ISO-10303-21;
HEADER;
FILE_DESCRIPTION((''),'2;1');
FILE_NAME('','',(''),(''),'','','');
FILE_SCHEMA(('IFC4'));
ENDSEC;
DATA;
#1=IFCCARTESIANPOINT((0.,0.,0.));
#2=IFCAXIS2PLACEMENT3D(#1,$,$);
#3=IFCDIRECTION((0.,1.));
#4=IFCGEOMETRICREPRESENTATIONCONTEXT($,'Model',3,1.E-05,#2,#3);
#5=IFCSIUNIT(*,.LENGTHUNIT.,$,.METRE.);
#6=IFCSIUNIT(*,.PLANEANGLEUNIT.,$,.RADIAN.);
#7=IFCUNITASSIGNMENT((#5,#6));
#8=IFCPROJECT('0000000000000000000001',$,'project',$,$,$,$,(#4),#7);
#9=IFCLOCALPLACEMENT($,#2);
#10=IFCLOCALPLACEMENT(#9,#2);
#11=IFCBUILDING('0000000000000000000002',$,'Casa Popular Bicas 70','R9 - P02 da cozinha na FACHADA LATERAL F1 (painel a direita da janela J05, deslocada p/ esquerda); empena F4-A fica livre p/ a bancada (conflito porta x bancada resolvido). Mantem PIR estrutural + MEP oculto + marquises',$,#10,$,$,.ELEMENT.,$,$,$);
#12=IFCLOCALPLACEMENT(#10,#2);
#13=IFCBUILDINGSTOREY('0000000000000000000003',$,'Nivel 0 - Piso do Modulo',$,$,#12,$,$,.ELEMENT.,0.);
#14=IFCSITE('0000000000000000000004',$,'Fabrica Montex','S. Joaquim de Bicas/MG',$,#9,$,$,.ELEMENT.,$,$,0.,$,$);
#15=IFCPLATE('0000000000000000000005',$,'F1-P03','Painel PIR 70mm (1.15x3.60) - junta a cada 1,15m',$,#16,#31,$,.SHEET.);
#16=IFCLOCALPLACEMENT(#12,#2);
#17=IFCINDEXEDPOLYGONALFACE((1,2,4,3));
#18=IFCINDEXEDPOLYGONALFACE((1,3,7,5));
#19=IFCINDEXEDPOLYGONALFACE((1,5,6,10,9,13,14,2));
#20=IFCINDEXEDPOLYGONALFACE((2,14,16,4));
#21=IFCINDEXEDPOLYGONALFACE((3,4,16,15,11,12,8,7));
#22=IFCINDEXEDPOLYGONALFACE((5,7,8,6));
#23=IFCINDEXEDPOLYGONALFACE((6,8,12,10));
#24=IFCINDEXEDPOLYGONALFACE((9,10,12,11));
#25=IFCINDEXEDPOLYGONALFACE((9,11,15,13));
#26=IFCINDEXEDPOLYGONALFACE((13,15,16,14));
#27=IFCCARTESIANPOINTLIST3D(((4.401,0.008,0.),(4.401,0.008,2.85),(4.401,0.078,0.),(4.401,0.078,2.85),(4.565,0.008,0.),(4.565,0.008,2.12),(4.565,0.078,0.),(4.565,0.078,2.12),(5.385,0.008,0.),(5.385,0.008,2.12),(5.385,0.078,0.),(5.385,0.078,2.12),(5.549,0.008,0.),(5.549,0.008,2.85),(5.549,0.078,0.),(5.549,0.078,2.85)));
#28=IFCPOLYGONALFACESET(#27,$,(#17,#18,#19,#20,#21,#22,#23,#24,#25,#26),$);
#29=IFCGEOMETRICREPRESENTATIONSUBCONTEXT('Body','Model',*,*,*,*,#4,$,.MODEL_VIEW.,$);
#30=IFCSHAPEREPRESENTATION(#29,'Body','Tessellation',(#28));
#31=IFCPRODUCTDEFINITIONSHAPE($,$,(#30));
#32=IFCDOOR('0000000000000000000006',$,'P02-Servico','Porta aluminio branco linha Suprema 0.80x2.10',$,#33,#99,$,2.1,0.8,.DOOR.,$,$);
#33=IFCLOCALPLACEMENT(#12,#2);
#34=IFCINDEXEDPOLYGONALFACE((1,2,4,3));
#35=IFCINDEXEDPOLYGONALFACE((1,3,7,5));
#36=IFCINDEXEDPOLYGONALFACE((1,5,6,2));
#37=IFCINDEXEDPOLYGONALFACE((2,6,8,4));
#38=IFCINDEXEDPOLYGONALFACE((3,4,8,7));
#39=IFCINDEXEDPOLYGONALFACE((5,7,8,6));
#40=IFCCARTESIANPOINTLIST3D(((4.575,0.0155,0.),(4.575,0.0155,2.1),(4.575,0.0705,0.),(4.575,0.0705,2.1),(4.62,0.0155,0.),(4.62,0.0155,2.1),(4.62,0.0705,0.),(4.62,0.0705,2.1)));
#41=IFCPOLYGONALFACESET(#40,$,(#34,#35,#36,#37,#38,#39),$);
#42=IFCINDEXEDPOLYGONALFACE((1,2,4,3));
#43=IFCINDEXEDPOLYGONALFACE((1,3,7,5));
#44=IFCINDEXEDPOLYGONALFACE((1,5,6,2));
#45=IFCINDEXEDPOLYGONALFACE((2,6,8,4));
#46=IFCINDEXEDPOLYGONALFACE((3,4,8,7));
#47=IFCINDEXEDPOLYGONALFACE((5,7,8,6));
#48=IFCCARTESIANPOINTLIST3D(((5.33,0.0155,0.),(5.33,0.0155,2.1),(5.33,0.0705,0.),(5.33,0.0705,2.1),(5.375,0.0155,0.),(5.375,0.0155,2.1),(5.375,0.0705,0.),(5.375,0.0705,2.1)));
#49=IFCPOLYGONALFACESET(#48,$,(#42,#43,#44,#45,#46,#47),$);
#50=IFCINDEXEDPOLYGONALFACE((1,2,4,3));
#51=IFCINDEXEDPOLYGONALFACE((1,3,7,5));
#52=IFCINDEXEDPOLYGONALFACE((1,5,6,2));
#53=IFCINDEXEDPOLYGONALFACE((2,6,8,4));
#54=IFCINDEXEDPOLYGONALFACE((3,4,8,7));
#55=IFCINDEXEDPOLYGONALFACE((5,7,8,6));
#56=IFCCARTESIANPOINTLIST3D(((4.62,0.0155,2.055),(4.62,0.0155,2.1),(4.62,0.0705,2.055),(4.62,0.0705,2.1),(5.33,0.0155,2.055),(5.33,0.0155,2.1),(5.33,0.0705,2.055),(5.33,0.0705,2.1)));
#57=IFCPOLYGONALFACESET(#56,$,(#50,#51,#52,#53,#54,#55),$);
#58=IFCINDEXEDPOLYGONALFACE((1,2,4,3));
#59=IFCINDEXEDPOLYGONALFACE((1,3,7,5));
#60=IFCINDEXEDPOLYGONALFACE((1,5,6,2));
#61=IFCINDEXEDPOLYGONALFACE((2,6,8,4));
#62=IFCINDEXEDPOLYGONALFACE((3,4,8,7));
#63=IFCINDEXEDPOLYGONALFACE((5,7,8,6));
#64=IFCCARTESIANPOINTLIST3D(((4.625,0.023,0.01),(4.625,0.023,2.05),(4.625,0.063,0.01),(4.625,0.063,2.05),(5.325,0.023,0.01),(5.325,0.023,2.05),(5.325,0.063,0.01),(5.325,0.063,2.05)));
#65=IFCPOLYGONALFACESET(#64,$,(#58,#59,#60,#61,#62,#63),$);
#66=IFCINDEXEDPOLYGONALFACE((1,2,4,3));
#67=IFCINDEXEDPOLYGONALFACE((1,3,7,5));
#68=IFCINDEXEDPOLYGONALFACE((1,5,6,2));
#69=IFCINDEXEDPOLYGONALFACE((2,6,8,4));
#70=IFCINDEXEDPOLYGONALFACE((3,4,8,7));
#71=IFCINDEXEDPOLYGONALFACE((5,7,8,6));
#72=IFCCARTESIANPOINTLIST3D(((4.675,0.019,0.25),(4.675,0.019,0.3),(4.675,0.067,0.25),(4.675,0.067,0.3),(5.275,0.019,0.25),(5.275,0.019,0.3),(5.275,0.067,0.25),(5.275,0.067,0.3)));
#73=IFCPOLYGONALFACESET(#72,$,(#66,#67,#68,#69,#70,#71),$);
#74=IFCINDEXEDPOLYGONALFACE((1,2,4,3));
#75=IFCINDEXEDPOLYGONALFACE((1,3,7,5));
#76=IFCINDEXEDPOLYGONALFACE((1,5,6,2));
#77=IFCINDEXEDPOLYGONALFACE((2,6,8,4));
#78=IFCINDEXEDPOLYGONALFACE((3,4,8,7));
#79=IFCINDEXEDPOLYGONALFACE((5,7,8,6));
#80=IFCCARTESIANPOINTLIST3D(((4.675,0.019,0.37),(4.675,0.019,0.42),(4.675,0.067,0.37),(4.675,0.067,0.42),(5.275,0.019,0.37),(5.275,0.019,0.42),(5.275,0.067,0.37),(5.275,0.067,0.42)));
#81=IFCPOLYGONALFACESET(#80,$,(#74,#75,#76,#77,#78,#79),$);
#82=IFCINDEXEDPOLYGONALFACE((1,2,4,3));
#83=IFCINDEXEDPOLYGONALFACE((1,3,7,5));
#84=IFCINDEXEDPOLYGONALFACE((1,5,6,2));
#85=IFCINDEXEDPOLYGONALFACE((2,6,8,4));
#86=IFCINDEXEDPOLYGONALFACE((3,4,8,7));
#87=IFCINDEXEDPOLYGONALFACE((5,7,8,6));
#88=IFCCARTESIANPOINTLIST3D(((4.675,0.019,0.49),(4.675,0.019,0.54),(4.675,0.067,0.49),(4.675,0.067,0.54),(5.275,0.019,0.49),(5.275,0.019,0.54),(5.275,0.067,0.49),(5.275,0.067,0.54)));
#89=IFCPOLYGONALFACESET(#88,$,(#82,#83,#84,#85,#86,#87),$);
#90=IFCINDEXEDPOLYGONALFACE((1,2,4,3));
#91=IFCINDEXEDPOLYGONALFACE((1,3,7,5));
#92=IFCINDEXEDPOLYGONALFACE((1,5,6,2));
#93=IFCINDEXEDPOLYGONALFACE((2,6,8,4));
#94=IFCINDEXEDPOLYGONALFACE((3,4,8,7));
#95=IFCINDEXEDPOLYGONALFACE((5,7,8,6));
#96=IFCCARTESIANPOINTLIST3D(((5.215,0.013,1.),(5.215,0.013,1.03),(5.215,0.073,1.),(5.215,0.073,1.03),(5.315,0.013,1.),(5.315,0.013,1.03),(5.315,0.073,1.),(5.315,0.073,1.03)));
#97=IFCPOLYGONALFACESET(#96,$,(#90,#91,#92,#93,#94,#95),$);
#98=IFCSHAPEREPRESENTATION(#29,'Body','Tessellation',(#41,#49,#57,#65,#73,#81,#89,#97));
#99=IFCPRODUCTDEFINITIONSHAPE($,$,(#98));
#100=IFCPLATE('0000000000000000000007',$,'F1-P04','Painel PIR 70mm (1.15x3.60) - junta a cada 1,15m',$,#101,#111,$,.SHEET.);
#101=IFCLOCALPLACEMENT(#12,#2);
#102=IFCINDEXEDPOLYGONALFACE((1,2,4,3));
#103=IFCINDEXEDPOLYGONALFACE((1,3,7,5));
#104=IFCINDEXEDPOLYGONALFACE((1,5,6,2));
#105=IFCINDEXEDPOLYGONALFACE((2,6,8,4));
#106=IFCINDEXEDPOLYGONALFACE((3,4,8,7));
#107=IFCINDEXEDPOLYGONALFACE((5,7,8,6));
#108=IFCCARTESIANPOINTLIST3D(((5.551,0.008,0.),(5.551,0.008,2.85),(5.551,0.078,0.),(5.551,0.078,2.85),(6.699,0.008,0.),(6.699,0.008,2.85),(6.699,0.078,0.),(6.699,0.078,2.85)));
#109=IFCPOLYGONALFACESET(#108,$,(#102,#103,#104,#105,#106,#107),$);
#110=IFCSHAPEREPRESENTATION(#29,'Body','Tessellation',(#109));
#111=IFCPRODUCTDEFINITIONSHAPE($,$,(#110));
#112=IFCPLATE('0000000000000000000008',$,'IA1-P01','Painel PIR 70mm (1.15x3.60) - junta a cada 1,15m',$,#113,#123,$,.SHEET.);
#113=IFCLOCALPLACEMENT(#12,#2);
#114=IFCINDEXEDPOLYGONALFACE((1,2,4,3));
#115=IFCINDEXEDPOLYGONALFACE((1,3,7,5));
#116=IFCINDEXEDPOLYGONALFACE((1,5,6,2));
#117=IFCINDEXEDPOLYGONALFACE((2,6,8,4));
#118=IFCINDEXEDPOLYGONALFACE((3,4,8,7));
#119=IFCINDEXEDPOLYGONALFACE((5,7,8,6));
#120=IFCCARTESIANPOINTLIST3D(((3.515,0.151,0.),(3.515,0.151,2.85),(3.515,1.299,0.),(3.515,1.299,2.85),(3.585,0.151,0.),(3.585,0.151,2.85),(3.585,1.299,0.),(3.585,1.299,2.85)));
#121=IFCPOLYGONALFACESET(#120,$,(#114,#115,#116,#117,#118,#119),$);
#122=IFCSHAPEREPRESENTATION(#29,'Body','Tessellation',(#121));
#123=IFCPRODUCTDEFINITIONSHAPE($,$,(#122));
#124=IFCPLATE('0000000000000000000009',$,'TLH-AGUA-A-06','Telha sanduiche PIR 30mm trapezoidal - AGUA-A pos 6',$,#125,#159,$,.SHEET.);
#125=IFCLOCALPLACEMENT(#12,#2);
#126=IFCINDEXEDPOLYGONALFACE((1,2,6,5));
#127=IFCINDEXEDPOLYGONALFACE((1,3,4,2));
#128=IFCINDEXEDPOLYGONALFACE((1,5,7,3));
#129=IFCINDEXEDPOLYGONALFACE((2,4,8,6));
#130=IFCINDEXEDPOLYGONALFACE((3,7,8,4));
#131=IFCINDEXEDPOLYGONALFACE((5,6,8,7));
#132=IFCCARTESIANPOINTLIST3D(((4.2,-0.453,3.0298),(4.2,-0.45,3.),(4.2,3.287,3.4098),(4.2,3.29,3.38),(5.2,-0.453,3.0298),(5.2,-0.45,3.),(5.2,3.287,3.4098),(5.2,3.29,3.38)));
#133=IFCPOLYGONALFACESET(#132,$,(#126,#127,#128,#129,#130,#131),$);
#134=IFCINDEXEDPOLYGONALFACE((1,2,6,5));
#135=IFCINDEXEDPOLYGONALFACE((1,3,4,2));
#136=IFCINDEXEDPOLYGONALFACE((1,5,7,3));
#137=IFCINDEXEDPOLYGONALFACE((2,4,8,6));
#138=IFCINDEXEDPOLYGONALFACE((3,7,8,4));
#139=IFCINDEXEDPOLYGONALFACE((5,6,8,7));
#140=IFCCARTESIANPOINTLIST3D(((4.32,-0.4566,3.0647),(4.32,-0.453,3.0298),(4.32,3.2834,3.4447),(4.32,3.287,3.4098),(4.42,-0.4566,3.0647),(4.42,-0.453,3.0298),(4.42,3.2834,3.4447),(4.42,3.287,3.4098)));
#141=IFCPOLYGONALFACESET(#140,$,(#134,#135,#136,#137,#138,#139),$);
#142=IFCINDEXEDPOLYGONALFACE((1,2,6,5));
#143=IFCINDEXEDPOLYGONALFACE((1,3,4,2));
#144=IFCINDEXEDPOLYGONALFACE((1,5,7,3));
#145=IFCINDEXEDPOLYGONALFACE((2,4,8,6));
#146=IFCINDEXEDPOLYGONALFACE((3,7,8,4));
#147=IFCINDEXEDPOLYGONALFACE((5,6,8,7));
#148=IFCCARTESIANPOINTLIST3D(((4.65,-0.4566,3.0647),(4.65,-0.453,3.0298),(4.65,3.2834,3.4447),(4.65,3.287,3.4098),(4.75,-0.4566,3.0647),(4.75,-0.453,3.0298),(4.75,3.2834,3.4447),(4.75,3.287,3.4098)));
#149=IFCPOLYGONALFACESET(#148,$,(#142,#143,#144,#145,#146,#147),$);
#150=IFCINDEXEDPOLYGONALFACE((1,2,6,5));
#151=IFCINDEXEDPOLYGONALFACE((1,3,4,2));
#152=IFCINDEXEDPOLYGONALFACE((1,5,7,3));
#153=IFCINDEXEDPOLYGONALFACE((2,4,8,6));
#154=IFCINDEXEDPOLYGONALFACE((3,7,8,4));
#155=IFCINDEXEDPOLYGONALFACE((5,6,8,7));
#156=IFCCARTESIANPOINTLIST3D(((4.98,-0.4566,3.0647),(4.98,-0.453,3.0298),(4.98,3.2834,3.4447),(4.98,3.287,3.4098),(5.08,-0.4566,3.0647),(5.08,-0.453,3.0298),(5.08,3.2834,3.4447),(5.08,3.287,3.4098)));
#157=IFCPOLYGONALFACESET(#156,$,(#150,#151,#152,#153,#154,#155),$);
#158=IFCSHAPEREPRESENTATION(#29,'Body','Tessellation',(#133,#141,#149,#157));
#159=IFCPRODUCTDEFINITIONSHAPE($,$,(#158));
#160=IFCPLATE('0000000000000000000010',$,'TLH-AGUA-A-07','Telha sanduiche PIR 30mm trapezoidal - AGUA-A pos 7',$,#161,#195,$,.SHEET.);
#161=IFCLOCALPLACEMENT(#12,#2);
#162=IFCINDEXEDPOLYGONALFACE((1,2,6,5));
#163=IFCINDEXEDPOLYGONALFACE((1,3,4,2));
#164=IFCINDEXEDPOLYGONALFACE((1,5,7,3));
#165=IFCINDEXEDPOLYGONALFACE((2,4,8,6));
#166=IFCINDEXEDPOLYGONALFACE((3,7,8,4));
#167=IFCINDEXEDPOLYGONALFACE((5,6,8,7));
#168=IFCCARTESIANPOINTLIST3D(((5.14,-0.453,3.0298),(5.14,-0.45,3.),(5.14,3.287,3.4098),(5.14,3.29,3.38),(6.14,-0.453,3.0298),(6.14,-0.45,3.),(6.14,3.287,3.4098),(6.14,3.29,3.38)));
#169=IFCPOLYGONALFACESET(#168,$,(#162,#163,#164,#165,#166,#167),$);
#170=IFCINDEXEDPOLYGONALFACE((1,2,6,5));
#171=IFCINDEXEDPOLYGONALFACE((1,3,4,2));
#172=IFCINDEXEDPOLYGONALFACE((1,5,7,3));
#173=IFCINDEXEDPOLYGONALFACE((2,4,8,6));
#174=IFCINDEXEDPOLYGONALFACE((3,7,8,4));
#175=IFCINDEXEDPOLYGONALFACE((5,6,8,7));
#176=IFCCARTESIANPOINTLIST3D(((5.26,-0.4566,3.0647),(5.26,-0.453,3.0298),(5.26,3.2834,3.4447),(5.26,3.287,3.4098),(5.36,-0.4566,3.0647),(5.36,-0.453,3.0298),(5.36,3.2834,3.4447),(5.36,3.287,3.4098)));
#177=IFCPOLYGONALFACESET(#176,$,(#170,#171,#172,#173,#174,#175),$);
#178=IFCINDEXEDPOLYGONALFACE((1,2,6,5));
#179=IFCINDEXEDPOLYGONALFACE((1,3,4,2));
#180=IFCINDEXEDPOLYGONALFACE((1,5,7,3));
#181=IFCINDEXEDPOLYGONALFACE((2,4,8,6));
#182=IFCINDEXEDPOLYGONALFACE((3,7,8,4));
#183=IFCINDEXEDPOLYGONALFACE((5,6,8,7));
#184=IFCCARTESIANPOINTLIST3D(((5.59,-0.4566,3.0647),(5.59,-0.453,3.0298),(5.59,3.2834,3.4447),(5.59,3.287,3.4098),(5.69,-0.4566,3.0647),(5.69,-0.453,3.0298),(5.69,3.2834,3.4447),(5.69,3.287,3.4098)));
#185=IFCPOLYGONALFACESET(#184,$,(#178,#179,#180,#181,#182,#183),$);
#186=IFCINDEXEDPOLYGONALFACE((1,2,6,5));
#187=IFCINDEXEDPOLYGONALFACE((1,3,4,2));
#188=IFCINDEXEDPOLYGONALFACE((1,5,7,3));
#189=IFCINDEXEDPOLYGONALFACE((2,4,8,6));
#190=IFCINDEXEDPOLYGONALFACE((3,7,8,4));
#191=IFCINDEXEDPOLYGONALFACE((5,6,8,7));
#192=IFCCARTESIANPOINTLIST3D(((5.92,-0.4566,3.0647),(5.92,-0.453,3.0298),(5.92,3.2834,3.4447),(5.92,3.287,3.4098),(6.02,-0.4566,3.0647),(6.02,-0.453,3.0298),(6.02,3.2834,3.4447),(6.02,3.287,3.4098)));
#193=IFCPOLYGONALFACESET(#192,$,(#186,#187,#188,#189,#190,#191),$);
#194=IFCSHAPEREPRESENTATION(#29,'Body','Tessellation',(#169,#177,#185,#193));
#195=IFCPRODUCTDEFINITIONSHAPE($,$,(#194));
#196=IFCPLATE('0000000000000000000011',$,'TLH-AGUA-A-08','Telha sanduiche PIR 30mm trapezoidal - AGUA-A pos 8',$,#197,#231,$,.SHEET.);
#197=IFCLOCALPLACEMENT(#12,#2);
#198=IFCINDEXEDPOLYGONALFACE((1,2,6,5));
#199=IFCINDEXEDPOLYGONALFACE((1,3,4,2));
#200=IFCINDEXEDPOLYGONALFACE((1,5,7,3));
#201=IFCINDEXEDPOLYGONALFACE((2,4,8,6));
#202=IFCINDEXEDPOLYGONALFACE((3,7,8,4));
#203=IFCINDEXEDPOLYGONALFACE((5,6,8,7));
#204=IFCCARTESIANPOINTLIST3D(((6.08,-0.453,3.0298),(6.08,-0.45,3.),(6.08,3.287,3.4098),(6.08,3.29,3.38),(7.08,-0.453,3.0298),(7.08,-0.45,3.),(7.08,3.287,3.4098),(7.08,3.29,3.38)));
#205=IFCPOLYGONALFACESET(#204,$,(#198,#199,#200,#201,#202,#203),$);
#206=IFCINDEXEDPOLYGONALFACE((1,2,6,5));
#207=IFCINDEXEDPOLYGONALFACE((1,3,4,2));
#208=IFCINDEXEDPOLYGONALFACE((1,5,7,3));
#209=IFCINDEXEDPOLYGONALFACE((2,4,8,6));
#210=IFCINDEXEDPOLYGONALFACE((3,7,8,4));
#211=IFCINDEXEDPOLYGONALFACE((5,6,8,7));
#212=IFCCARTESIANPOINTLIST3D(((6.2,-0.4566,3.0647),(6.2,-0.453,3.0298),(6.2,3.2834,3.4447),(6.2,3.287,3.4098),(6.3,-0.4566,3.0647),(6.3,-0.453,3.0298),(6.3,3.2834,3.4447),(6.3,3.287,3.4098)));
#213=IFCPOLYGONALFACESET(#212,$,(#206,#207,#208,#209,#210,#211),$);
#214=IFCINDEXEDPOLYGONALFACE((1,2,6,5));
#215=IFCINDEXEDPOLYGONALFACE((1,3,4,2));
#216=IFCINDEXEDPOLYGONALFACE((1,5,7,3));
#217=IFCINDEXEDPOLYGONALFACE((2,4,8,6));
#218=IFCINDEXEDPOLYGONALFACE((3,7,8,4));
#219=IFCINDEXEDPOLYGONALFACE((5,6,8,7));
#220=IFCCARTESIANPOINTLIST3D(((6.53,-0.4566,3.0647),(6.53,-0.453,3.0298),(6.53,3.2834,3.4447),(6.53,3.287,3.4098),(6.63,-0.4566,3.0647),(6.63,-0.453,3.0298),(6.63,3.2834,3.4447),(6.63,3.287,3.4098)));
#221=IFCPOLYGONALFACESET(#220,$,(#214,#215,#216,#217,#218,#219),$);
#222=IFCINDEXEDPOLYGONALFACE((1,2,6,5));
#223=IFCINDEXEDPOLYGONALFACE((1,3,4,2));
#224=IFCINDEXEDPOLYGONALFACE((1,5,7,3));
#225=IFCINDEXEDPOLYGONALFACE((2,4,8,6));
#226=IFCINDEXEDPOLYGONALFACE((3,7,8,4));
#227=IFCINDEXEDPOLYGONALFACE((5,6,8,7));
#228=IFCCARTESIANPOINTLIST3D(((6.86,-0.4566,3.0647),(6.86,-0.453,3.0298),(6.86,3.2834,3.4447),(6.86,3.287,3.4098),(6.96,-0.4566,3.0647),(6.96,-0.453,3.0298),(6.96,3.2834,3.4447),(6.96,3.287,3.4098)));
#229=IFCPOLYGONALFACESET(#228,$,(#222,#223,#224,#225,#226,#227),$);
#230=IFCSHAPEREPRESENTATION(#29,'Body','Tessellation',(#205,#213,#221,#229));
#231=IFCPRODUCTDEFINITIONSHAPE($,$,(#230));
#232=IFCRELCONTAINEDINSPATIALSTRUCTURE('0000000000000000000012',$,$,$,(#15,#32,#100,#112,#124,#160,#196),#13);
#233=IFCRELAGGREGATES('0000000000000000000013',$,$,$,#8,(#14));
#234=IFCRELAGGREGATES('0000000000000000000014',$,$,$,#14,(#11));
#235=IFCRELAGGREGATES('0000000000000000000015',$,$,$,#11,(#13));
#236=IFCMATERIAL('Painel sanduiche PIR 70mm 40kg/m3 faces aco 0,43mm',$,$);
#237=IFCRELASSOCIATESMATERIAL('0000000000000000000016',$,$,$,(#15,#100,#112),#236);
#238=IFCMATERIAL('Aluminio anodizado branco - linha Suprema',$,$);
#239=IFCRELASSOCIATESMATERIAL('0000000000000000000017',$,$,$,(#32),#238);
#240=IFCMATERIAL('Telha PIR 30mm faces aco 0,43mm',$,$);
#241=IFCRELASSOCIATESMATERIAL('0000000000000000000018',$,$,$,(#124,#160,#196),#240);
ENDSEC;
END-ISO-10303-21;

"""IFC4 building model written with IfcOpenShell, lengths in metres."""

from ifc_helpers import new_model, si_unit, direction, frame, frame_2d, origin, place, context, subcontext, project, spatial, rectangle, extrude, material, element, fill, save


model = new_model("IFC4")

# Units and contexts
model_context = context("Model", 3, precision=1e-05, world=origin(), true_north=direction((0.0, 1.0)))
body_context = subcontext(model_context, "Body", "Model", "MODEL_VIEW")
ifc_project = project(units=[si_unit("LENGTHUNIT", "METRE"), si_unit("PLANEANGLEUNIT", "RADIAN")], contexts=[model_context])

# Site, building, storey
site_placement = place(None, origin())
site = spatial("IfcSite", under=ifc_project, at=site_placement, Name="Fabrica Montex", Description="S. Joaquim de Bicas/MG", CompositionType="ELEMENT", RefElevation=0.0)
building_placement = place(site_placement, origin())
building = spatial("IfcBuilding", under=site, at=building_placement, Name="Casa Popular Bicas 70", Description="R9 - P02 da cozinha na FACHADA LATERAL F1 (painel a direita da janela J05, deslocada p/ esquerda); empena F4-A fica livre p/ a bancada (conflito porta x bancada resolvido). Mantem PIR estrutural + MEP oculto + marquises", CompositionType="ELEMENT")
storey_placement = place(building_placement, origin())
storey = spatial("IfcBuildingStorey", under=building, at=storey_placement, Name="Nivel 0 - Piso do Modulo", CompositionType="ELEMENT", Elevation=0.0)

# Shared definitions
ifc_material_1 = material(Name="Aluminio anodizado branco - linha Suprema")

# Plate, opening, door
ifc_material_2 = material(Name="Painel sanduiche PIR 70mm 40kg/m3 faces aco 0,43mm")
plate_placement = place(storey_placement, frame((4.401, 0.043, 0.0), x_axis=(1.0, 0.0, 0.0)))
plate = element("IfcPlate", 1, at=plate_placement, inside=storey, material=ifc_material_2, Name="F1-P03", Description="Painel PIR 70mm (1.15x3.60) - junta a cada 1,15m", PredefinedType="SHEET", context=body_context, shape_type="SweptSolid", body=[
    extrude(rectangle(XDim=1.148, YDim=0.07, at=frame_2d((0.574, 0.0))), origin(), (0.0, 0.0, 1.0), 2.85),
])
opening_placement = place(storey_placement, frame((4.575, 0.043, 0.0)))
opening = element("IfcOpeningElement", 2, at=opening_placement, cuts=plate, PredefinedType="OPENING", context=body_context, shape_type="SweptSolid", body=[
    extrude(rectangle(XDim=0.82, YDim=0.3, at=frame_2d((0.4, 0.0))), origin(), (0.0, 0.0, 1.0), 2.12),
])
door_placement = place(storey_placement, frame((4.575, 0.043, 0.0), x_axis=(1.0, 0.0, 0.0)))
door = element("IfcDoor", 3, at=door_placement, inside=storey, material=ifc_material_1, Name="P02-Servico", Description="Porta aluminio branco linha Suprema 0.80x2.10", OverallHeight=2.1, OverallWidth=0.8, PredefinedType="DOOR", context=body_context, shape_type="SweptSolid", body=[
    extrude(rectangle(XDim=0.045, YDim=0.055, at=frame_2d((0.0225, 0.0))), origin(), (0.0, 0.0, 1.0), 2.1),
    extrude(rectangle(XDim=0.045, YDim=0.055, at=frame_2d((0.7775, 0.0))), origin(), (0.0, 0.0, 1.0), 2.1),
    extrude(rectangle(XDim=0.71, YDim=0.055, at=frame_2d((0.4, 0.0))), frame((0.0, 0.0, 2.055)), (0.0, 0.0, 1.0), 0.045),
    extrude(rectangle(XDim=0.7, YDim=0.04, at=frame_2d((0.4, 0.0))), frame((0.0, 0.0, 0.01)), (0.0, 0.0, 1.0), 2.04),
    extrude(rectangle(XDim=0.6, YDim=0.048, at=frame_2d((0.4, 0.0))), frame((0.0, 0.0, 0.25)), (0.0, 0.0, 1.0), 0.05),
    extrude(rectangle(XDim=0.6, YDim=0.048, at=frame_2d((0.4, 0.0))), frame((0.0, 0.0, 0.37)), (0.0, 0.0, 1.0), 0.05),
    extrude(rectangle(XDim=0.6, YDim=0.048, at=frame_2d((0.4, 0.0))), frame((0.0, 0.0, 0.49)), (0.0, 0.0, 1.0), 0.05),
    extrude(rectangle(XDim=0.1, YDim=0.06, at=frame_2d((0.69, 0.0))), frame((0.0, 0.0, 1.0)), (0.0, 0.0, 1.0), 0.03),
])
fill(opening, door)

# Plates
for number, where, x_axis, name in (
    (4, (5.551, 0.043, 0.0), (1.0, 0.0, 0.0), "F1-P04"),
    (5, (3.55, 0.151, 0.0), (0.0, 1.0, 0.0), "IA1-P01"),
):
    element("IfcPlate", number, at=place(storey_placement, frame(where, x_axis=x_axis)), inside=storey, material=ifc_material_2, Name=name, Description="Painel PIR 70mm (1.15x3.60) - junta a cada 1,15m", PredefinedType="SHEET", context=body_context, shape_type="SweptSolid", body=[
        extrude(rectangle(XDim=1.148, YDim=0.07, at=frame_2d((0.574, 0.0))), origin(), (0.0, 0.0, 1.0), 2.85),
    ])
ifc_material_3 = material(Name="Telha PIR 30mm faces aco 0,43mm")
for number, where, z_axis, x_axis, name, description in (
    (6, (4.2, -0.45, 3.0), (0.0, -0.101084, 0.994878), (1.0, 0.0, 0.0), "TLH-AGUA-A-06", "Telha sanduiche PIR 30mm trapezoidal - AGUA-A pos 6"),
    (7, (5.14, -0.45, 3.0), (0.0, -0.101084, 0.994878), (1.0, 0.0, 0.0), "TLH-AGUA-A-07", "Telha sanduiche PIR 30mm trapezoidal - AGUA-A pos 7"),
    (8, (6.08, -0.45, 3.0), (0.0, -0.101084, 0.994878), (1.0, 0.0, 0.0), "TLH-AGUA-A-08", "Telha sanduiche PIR 30mm trapezoidal - AGUA-A pos 8"),
):
    element("IfcPlate", number, at=place(storey_placement, frame(where, z_axis=z_axis, x_axis=x_axis)), inside=storey, material=ifc_material_3, Name=name, Description=description, PredefinedType="SHEET", context=body_context, shape_type="SweptSolid", body=[
        extrude(rectangle(XDim=1.0, YDim=3.7593, at=frame_2d((0.5, 1.8796))), origin(), (0.0, 0.0, 1.0), 0.03),
        extrude(rectangle(XDim=0.1, YDim=3.7593, at=frame_2d((0.17, 1.8796))), frame((0.0, 0.0, 0.03)), (0.0, 0.0, 1.0), 0.035),
        extrude(rectangle(XDim=0.1, YDim=3.7593, at=frame_2d((0.5, 1.8796))), frame((0.0, 0.0, 0.03)), (0.0, 0.0, 1.0), 0.035),
        extrude(rectangle(XDim=0.1, YDim=3.7593, at=frame_2d((0.83, 1.8796))), frame((0.0, 0.0, 0.03)), (0.0, 0.0, 1.0), 0.035),
    ])

save(model, "model.ifc")
